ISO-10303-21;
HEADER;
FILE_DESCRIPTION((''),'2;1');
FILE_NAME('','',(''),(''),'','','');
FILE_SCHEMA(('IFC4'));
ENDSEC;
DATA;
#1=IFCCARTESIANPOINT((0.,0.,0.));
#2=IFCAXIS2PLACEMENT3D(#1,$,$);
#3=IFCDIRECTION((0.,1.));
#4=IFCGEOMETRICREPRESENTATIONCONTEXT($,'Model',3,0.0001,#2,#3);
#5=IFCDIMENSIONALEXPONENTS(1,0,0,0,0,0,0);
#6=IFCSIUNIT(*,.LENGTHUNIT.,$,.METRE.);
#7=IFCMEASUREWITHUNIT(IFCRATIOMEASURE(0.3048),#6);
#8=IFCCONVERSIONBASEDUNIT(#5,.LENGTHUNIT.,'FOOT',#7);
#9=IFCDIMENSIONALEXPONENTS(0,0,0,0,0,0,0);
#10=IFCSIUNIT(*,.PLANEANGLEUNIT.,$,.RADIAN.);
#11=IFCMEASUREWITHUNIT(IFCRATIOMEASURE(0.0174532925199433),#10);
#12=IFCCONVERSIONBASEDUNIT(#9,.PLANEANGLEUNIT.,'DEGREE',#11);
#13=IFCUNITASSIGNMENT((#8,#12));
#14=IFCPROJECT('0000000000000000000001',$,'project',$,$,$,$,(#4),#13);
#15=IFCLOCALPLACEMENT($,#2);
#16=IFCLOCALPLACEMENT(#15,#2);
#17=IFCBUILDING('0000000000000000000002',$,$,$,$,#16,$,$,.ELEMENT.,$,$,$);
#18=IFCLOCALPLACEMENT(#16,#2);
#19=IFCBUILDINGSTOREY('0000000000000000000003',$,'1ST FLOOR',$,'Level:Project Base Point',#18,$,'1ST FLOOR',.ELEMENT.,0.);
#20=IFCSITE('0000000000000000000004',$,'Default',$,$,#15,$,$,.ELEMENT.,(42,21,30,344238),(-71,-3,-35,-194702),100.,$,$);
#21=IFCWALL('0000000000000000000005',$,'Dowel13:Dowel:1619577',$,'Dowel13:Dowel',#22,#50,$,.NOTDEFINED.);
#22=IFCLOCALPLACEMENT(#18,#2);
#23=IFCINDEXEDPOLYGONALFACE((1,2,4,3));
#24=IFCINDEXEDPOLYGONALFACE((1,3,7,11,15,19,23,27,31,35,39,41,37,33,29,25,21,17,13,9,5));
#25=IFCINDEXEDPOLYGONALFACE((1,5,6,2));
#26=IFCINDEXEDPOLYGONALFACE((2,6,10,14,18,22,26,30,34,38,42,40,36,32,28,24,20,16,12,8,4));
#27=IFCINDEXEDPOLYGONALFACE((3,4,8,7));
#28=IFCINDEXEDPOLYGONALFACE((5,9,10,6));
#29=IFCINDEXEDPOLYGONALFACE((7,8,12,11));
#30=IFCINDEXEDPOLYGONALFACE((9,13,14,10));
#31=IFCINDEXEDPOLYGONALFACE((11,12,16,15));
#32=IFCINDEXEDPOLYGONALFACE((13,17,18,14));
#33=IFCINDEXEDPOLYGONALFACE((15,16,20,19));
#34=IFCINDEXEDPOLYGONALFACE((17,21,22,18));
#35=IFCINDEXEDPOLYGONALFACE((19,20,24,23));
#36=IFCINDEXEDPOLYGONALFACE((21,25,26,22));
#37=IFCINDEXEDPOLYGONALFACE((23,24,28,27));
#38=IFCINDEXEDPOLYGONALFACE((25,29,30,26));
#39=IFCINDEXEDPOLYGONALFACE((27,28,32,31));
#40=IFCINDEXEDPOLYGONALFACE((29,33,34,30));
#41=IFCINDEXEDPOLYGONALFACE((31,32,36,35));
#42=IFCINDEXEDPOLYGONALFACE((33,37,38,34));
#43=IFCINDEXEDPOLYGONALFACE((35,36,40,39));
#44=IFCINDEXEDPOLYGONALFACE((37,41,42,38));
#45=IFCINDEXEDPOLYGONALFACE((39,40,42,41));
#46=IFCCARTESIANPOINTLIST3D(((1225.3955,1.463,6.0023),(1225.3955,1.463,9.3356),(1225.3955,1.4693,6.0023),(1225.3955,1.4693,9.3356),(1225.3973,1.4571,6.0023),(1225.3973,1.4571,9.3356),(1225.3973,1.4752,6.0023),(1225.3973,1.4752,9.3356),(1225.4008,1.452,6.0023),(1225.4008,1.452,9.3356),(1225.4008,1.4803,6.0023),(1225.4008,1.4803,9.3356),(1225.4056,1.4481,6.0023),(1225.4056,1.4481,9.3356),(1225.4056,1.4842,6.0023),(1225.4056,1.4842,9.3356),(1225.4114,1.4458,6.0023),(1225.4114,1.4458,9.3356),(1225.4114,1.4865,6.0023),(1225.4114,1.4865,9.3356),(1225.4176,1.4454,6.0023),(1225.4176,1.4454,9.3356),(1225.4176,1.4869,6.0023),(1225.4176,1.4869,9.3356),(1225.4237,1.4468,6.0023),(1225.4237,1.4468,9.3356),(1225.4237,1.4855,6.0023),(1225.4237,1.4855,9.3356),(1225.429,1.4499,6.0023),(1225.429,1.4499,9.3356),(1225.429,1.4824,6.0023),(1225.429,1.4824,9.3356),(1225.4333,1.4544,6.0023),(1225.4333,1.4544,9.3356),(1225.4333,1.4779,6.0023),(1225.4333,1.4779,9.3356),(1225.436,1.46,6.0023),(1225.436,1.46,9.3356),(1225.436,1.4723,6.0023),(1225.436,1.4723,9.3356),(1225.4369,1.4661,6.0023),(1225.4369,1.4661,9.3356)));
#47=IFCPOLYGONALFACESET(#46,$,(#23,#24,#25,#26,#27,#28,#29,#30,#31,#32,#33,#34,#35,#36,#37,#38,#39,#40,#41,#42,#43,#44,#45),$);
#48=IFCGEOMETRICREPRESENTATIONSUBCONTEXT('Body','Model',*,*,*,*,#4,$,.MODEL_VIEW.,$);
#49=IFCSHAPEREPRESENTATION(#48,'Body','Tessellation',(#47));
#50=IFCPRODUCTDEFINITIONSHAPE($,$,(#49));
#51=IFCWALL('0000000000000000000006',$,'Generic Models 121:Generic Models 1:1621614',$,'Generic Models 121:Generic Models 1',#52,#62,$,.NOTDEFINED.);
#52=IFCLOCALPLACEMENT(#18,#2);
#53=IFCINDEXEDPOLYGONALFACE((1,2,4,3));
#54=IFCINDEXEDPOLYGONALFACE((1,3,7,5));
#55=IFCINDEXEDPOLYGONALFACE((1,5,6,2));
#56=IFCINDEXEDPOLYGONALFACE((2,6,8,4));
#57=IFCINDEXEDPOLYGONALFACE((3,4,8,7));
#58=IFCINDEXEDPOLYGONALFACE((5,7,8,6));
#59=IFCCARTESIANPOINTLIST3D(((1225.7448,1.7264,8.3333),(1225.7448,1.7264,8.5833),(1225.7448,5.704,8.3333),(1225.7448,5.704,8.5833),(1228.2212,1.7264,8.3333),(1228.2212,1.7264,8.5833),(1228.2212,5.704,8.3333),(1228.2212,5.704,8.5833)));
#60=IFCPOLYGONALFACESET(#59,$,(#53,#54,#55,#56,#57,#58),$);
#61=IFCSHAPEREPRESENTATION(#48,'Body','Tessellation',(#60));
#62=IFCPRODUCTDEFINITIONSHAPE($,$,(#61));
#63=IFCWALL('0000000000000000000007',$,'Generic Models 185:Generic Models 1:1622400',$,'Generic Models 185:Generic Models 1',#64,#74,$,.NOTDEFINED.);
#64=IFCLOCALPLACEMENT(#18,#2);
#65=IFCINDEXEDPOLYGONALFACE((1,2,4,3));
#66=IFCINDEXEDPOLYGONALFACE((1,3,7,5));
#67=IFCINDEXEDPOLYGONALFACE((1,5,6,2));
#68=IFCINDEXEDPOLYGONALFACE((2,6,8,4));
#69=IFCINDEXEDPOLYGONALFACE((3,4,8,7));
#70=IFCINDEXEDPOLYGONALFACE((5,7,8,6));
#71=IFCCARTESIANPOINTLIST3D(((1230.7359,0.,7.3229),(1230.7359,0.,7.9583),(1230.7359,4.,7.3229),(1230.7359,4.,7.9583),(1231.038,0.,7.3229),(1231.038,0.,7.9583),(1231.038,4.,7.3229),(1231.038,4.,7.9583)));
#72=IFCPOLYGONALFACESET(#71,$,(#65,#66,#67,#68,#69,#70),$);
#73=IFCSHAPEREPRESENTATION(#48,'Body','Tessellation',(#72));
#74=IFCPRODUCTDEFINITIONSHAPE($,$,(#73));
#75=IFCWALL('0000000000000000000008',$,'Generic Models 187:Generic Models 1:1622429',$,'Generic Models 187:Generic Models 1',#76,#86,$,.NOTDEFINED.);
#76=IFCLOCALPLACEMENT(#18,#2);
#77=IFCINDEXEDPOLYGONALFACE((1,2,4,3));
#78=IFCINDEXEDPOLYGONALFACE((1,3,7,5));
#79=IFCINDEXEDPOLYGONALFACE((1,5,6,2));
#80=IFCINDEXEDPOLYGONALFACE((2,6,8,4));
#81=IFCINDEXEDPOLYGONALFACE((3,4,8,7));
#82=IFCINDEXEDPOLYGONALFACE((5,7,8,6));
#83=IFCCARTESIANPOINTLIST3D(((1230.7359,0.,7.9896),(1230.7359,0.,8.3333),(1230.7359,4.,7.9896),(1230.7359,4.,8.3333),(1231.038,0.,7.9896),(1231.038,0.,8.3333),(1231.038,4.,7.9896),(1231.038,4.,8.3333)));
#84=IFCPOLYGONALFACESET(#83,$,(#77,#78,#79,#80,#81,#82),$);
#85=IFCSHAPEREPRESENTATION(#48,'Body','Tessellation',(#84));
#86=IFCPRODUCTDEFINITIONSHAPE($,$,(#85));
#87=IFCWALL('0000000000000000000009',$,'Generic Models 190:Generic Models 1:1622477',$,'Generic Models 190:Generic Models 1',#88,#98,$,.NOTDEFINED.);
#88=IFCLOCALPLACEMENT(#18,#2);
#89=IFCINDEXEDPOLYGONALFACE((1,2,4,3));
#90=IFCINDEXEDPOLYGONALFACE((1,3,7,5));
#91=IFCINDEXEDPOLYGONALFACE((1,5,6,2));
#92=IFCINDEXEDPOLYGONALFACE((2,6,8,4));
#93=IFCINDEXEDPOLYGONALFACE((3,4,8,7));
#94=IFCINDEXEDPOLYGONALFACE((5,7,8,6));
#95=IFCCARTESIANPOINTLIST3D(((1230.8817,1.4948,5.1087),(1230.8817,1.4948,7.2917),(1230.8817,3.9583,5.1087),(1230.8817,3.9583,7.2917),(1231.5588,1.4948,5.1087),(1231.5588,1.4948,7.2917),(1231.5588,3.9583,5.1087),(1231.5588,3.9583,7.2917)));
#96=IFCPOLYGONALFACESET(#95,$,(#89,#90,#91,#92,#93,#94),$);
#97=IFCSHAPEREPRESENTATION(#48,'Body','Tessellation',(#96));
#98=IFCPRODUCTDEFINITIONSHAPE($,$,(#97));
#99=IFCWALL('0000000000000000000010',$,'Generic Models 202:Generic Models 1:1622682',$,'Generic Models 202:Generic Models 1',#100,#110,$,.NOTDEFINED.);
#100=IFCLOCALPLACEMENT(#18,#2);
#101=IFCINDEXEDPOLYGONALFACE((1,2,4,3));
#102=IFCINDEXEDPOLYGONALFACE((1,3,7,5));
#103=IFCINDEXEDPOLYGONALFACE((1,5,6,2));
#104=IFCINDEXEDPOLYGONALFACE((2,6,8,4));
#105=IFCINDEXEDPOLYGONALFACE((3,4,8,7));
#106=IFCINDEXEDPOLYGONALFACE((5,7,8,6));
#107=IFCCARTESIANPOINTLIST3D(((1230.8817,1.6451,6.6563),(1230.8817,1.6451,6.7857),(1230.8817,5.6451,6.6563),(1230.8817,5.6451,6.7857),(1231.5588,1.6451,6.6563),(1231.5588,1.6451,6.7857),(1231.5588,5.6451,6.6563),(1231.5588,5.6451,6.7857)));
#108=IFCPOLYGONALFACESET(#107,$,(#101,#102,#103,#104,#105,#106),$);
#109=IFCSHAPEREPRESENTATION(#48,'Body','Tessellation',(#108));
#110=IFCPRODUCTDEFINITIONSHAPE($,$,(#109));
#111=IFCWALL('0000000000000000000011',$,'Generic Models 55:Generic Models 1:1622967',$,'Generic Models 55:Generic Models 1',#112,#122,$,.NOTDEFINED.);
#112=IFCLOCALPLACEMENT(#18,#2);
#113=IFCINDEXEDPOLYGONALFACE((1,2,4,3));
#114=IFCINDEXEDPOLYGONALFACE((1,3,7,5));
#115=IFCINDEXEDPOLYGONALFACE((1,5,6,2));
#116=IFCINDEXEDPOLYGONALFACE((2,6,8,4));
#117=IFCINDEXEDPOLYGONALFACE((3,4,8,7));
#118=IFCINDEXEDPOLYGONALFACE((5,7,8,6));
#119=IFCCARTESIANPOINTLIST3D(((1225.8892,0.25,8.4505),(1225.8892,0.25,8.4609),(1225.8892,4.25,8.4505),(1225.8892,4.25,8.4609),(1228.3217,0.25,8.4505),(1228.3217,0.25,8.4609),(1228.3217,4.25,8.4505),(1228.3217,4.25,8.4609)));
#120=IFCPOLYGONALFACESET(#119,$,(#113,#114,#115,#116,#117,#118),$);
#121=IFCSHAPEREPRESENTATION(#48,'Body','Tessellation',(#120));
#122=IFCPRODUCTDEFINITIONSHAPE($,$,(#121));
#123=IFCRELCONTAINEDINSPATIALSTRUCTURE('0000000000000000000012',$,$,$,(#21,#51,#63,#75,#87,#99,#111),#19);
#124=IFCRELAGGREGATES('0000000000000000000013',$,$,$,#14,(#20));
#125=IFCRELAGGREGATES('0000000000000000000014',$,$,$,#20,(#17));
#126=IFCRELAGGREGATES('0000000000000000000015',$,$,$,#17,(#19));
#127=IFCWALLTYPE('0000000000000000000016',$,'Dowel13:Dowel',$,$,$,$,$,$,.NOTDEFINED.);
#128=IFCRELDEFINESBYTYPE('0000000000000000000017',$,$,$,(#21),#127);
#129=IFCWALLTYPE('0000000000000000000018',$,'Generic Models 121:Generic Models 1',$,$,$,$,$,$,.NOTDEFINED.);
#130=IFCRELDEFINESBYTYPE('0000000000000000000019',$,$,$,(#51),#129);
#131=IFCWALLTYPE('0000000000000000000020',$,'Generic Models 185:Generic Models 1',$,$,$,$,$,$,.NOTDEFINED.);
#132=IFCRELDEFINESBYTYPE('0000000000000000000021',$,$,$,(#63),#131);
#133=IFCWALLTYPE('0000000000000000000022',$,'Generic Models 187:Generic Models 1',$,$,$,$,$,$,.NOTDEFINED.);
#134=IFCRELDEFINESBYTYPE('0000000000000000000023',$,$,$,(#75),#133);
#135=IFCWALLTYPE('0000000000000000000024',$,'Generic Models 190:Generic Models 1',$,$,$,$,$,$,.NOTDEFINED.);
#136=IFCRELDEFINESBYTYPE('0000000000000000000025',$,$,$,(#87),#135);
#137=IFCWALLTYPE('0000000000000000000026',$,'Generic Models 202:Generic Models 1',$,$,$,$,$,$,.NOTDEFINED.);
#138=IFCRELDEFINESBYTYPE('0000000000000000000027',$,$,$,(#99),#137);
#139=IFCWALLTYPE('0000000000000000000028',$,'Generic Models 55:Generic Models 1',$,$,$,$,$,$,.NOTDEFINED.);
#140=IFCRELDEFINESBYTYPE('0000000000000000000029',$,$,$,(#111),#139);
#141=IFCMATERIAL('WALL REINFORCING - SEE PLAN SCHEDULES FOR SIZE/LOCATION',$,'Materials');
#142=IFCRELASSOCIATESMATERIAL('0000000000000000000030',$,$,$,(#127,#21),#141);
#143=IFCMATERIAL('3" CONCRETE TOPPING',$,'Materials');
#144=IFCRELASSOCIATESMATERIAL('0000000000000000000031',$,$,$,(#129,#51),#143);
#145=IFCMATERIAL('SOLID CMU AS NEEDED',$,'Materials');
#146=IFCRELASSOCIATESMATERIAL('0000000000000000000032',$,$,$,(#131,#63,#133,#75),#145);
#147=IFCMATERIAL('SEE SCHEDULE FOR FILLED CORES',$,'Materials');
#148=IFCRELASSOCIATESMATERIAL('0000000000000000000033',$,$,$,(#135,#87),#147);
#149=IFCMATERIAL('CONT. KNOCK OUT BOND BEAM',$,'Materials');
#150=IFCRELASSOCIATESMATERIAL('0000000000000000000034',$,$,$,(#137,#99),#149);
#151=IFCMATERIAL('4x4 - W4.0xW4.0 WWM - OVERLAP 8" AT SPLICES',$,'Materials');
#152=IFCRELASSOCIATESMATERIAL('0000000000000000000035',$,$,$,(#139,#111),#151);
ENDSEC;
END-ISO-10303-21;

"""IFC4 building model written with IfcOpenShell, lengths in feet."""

from ifc_helpers import new_model, entity, si_unit, converted_unit, direction, frame, frame_2d, origin, origin_2d_with_axis, place, context, subcontext, project, spatial, rectangle, circle, extrude, material, type_object, element, save


model = new_model("IFC4")

# Units and contexts
model_context = context("Model", 3, precision=0.0001, world=origin(), true_north=direction((0.0, 1.0)))
body_context = subcontext(model_context, "Body", "Model", "MODEL_VIEW")
ifc_project = project(units=[converted_unit("LENGTHUNIT", "FOOT", entity("IfcRatioMeasure", 0.3048), si_unit("LENGTHUNIT", "METRE"), dimensions=[1, 0, 0, 0, 0, 0, 0]), converted_unit("PLANEANGLEUNIT", "DEGREE", entity("IfcRatioMeasure", 0.0174532925199433), si_unit("PLANEANGLEUNIT", "RADIAN"), dimensions=[0, 0, 0, 0, 0, 0, 0])], contexts=[model_context])

# Site, building, storey
site_placement = place(None, origin())
site = spatial("IfcSite", under=ifc_project, at=site_placement, Name="Default", CompositionType="ELEMENT", RefLatitude=(42, 21, 30, 344238), RefLongitude=(-71, -3, -35, -194702), RefElevation=100.0)
building_placement = place(site_placement, origin())
building = spatial("IfcBuilding", under=site, at=building_placement, CompositionType="ELEMENT")
storey_placement = place(building_placement, origin())
storey = spatial("IfcBuildingStorey", under=building, at=storey_placement, Name="1ST FLOOR", ObjectType="Level:Project Base Point", LongName="1ST FLOOR", CompositionType="ELEMENT", Elevation=0.0)

# Walls
ifc_material_1 = material(Name="WALL REINFORCING - SEE PLAN SCHEDULES FOR SIZE/LOCATION", Category="Materials")
wall_type_1 = type_object("IfcWallType", Name="Dowel13:Dowel", PredefinedType="NOTDEFINED", material=ifc_material_1)
wall_1_placement = place(storey_placement, frame((1225.3952, 1.4453, 6.0023), z_axis=(0.0, 0.0, 1.0), x_axis=(0.0, 1.0, 0.0)))
element("IfcWall", 1, at=wall_1_placement, inside=storey, type_object=wall_type_1, material=ifc_material_1, Name="Dowel13:Dowel:1619577", ObjectType="Dowel13:Dowel", PredefinedType="NOTDEFINED", context=body_context, shape_type="SweptSolid", body=[
    extrude(circle(Radius=0.0208, at=origin_2d_with_axis()), frame((0.0208, -0.0208, 0.0), z_axis=(0.0, 0.0, 1.0), x_axis=(0.0, -1.0, 0.0)), (0.0, 0.0, 1.0), 3.3333),
])
ifc_material_2 = material(Name="3\" CONCRETE TOPPING", Category="Materials")
wall_type_2 = type_object("IfcWallType", Name="Generic Models 121:Generic Models 1", PredefinedType="NOTDEFINED", material=ifc_material_2)
wall_2_placement = place(storey_placement, frame((1225.7448, 1.7264, 8.3333), z_axis=(0.0, 0.0, 1.0), x_axis=(0.0, 1.0, 0.0)))
element("IfcWall", 2, at=wall_2_placement, inside=storey, type_object=wall_type_2, material=ifc_material_2, Name="Generic Models 121:Generic Models 1:1621614", ObjectType="Generic Models 121:Generic Models 1", PredefinedType="NOTDEFINED", context=body_context, shape_type="SweptSolid", body=[
    extrude(rectangle(XDim=3.9776, YDim=2.4764, at=frame_2d((0.0, 0.0), x_axis=(1.0, 0.0))), frame((1.9888, -1.2382, 0.0)), (0.0, 0.0, 1.0), 0.25),
])

# Walls
ifc_material_3 = material(Name="SOLID CMU AS NEEDED", Category="Materials")
wall_type_3 = type_object("IfcWallType", Name="Generic Models 185:Generic Models 1", PredefinedType="NOTDEFINED", material=ifc_material_3)
wall_3_placement = place(storey_placement, frame((1230.7359, 0.0, 7.3229), z_axis=(0.0, 0.0, 1.0), x_axis=(0.0, 1.0, 0.0)))
element("IfcWall", 3, at=wall_3_placement, inside=storey, type_object=wall_type_3, material=ifc_material_3, Name="Generic Models 185:Generic Models 1:1622400", ObjectType="Generic Models 185:Generic Models 1", PredefinedType="NOTDEFINED", context=body_context, shape_type="SweptSolid", body=[
    extrude(rectangle(XDim=4.0, YDim=0.3021, at=frame_2d((0.0, 0.0), x_axis=(1.0, 0.0))), frame((2.0, -0.151, 0.0), z_axis=(0.0, 0.0, 1.0), x_axis=(-1.0, 0.0, 0.0)), (0.0, 0.0, 1.0), 0.6354),
])
wall_type_4 = type_object("IfcWallType", Name="Generic Models 187:Generic Models 1", PredefinedType="NOTDEFINED", material=ifc_material_3)
wall_4_placement = place(storey_placement, frame((1230.7359, 0.0, 7.9896), z_axis=(0.0, 0.0, 1.0), x_axis=(0.0, 1.0, 0.0)))
element("IfcWall", 4, at=wall_4_placement, inside=storey, type_object=wall_type_4, material=ifc_material_3, Name="Generic Models 187:Generic Models 1:1622429", ObjectType="Generic Models 187:Generic Models 1", PredefinedType="NOTDEFINED", context=body_context, shape_type="SweptSolid", body=[
    extrude(rectangle(XDim=4.0, YDim=0.3021, at=frame_2d((0.0, 0.0), x_axis=(1.0, 0.0))), frame((2.0, -0.151, 0.0), z_axis=(0.0, 0.0, 1.0), x_axis=(-1.0, 0.0, 0.0)), (0.0, 0.0, 1.0), 0.3437),
])

# Wall
ifc_material_4 = material(Name="SEE SCHEDULE FOR FILLED CORES", Category="Materials")
wall_type_5 = type_object("IfcWallType", Name="Generic Models 190:Generic Models 1", PredefinedType="NOTDEFINED", material=ifc_material_4)
wall_5_placement = place(storey_placement, frame((1230.8817, 1.4948, 5.1087), z_axis=(0.0, 0.0, 1.0), x_axis=(0.0, 1.0, 0.0)))
element("IfcWall", 5, at=wall_5_placement, inside=storey, type_object=wall_type_5, material=ifc_material_4, Name="Generic Models 190:Generic Models 1:1622477", ObjectType="Generic Models 190:Generic Models 1", PredefinedType="NOTDEFINED", context=body_context, shape_type="SweptSolid", body=[
    extrude(rectangle(XDim=2.4635, YDim=0.6771, at=frame_2d((0.0, 0.0), x_axis=(1.0, 0.0))), frame((1.2318, -0.3385, 0.0)), (0.0, 0.0, 1.0), 2.1829),
])

# Shared definitions
ifc_material_5 = material(Name="CONT. KNOCK OUT BOND BEAM", Category="Materials")

# Walls
wall_type_6 = type_object("IfcWallType", Name="Generic Models 202:Generic Models 1", PredefinedType="NOTDEFINED", material=ifc_material_5)
wall_6_placement = place(storey_placement, frame((1230.8817, 1.6451, 6.6563), z_axis=(0.0, 0.0, 1.0), x_axis=(0.0, 1.0, 0.0)))
element("IfcWall", 6, at=wall_6_placement, inside=storey, type_object=wall_type_6, material=ifc_material_5, Name="Generic Models 202:Generic Models 1:1622682", ObjectType="Generic Models 202:Generic Models 1", PredefinedType="NOTDEFINED", context=body_context, shape_type="SweptSolid", body=[
    extrude(rectangle(XDim=4.0, YDim=0.6771, at=frame_2d((0.0, 0.0), x_axis=(1.0, 0.0))), frame((2.0, -0.3385, 0.0)), (0.0, 0.0, 1.0), 0.1295),
])
ifc_material_6 = material(Name="4x4 - W4.0xW4.0 WWM - OVERLAP 8\" AT SPLICES", Category="Materials")
wall_type_7 = type_object("IfcWallType", Name="Generic Models 55:Generic Models 1", PredefinedType="NOTDEFINED", material=ifc_material_6)
wall_7_placement = place(storey_placement, frame((1225.8892, 0.25, 8.4505), z_axis=(0.0, 0.0, 1.0), x_axis=(0.0, 1.0, 0.0)))
element("IfcWall", 7, at=wall_7_placement, inside=storey, type_object=wall_type_7, material=ifc_material_6, Name="Generic Models 55:Generic Models 1:1622967", ObjectType="Generic Models 55:Generic Models 1", PredefinedType="NOTDEFINED", context=body_context, shape_type="SweptSolid", body=[
    extrude(rectangle(XDim=4.0, YDim=2.4325, at=frame_2d((0.0, 0.0), x_axis=(1.0, 0.0))), frame((2.0, -1.2162, 0.0)), (0.0, 0.0, 1.0), 0.0104),
])

save(model, "model.ifc")
